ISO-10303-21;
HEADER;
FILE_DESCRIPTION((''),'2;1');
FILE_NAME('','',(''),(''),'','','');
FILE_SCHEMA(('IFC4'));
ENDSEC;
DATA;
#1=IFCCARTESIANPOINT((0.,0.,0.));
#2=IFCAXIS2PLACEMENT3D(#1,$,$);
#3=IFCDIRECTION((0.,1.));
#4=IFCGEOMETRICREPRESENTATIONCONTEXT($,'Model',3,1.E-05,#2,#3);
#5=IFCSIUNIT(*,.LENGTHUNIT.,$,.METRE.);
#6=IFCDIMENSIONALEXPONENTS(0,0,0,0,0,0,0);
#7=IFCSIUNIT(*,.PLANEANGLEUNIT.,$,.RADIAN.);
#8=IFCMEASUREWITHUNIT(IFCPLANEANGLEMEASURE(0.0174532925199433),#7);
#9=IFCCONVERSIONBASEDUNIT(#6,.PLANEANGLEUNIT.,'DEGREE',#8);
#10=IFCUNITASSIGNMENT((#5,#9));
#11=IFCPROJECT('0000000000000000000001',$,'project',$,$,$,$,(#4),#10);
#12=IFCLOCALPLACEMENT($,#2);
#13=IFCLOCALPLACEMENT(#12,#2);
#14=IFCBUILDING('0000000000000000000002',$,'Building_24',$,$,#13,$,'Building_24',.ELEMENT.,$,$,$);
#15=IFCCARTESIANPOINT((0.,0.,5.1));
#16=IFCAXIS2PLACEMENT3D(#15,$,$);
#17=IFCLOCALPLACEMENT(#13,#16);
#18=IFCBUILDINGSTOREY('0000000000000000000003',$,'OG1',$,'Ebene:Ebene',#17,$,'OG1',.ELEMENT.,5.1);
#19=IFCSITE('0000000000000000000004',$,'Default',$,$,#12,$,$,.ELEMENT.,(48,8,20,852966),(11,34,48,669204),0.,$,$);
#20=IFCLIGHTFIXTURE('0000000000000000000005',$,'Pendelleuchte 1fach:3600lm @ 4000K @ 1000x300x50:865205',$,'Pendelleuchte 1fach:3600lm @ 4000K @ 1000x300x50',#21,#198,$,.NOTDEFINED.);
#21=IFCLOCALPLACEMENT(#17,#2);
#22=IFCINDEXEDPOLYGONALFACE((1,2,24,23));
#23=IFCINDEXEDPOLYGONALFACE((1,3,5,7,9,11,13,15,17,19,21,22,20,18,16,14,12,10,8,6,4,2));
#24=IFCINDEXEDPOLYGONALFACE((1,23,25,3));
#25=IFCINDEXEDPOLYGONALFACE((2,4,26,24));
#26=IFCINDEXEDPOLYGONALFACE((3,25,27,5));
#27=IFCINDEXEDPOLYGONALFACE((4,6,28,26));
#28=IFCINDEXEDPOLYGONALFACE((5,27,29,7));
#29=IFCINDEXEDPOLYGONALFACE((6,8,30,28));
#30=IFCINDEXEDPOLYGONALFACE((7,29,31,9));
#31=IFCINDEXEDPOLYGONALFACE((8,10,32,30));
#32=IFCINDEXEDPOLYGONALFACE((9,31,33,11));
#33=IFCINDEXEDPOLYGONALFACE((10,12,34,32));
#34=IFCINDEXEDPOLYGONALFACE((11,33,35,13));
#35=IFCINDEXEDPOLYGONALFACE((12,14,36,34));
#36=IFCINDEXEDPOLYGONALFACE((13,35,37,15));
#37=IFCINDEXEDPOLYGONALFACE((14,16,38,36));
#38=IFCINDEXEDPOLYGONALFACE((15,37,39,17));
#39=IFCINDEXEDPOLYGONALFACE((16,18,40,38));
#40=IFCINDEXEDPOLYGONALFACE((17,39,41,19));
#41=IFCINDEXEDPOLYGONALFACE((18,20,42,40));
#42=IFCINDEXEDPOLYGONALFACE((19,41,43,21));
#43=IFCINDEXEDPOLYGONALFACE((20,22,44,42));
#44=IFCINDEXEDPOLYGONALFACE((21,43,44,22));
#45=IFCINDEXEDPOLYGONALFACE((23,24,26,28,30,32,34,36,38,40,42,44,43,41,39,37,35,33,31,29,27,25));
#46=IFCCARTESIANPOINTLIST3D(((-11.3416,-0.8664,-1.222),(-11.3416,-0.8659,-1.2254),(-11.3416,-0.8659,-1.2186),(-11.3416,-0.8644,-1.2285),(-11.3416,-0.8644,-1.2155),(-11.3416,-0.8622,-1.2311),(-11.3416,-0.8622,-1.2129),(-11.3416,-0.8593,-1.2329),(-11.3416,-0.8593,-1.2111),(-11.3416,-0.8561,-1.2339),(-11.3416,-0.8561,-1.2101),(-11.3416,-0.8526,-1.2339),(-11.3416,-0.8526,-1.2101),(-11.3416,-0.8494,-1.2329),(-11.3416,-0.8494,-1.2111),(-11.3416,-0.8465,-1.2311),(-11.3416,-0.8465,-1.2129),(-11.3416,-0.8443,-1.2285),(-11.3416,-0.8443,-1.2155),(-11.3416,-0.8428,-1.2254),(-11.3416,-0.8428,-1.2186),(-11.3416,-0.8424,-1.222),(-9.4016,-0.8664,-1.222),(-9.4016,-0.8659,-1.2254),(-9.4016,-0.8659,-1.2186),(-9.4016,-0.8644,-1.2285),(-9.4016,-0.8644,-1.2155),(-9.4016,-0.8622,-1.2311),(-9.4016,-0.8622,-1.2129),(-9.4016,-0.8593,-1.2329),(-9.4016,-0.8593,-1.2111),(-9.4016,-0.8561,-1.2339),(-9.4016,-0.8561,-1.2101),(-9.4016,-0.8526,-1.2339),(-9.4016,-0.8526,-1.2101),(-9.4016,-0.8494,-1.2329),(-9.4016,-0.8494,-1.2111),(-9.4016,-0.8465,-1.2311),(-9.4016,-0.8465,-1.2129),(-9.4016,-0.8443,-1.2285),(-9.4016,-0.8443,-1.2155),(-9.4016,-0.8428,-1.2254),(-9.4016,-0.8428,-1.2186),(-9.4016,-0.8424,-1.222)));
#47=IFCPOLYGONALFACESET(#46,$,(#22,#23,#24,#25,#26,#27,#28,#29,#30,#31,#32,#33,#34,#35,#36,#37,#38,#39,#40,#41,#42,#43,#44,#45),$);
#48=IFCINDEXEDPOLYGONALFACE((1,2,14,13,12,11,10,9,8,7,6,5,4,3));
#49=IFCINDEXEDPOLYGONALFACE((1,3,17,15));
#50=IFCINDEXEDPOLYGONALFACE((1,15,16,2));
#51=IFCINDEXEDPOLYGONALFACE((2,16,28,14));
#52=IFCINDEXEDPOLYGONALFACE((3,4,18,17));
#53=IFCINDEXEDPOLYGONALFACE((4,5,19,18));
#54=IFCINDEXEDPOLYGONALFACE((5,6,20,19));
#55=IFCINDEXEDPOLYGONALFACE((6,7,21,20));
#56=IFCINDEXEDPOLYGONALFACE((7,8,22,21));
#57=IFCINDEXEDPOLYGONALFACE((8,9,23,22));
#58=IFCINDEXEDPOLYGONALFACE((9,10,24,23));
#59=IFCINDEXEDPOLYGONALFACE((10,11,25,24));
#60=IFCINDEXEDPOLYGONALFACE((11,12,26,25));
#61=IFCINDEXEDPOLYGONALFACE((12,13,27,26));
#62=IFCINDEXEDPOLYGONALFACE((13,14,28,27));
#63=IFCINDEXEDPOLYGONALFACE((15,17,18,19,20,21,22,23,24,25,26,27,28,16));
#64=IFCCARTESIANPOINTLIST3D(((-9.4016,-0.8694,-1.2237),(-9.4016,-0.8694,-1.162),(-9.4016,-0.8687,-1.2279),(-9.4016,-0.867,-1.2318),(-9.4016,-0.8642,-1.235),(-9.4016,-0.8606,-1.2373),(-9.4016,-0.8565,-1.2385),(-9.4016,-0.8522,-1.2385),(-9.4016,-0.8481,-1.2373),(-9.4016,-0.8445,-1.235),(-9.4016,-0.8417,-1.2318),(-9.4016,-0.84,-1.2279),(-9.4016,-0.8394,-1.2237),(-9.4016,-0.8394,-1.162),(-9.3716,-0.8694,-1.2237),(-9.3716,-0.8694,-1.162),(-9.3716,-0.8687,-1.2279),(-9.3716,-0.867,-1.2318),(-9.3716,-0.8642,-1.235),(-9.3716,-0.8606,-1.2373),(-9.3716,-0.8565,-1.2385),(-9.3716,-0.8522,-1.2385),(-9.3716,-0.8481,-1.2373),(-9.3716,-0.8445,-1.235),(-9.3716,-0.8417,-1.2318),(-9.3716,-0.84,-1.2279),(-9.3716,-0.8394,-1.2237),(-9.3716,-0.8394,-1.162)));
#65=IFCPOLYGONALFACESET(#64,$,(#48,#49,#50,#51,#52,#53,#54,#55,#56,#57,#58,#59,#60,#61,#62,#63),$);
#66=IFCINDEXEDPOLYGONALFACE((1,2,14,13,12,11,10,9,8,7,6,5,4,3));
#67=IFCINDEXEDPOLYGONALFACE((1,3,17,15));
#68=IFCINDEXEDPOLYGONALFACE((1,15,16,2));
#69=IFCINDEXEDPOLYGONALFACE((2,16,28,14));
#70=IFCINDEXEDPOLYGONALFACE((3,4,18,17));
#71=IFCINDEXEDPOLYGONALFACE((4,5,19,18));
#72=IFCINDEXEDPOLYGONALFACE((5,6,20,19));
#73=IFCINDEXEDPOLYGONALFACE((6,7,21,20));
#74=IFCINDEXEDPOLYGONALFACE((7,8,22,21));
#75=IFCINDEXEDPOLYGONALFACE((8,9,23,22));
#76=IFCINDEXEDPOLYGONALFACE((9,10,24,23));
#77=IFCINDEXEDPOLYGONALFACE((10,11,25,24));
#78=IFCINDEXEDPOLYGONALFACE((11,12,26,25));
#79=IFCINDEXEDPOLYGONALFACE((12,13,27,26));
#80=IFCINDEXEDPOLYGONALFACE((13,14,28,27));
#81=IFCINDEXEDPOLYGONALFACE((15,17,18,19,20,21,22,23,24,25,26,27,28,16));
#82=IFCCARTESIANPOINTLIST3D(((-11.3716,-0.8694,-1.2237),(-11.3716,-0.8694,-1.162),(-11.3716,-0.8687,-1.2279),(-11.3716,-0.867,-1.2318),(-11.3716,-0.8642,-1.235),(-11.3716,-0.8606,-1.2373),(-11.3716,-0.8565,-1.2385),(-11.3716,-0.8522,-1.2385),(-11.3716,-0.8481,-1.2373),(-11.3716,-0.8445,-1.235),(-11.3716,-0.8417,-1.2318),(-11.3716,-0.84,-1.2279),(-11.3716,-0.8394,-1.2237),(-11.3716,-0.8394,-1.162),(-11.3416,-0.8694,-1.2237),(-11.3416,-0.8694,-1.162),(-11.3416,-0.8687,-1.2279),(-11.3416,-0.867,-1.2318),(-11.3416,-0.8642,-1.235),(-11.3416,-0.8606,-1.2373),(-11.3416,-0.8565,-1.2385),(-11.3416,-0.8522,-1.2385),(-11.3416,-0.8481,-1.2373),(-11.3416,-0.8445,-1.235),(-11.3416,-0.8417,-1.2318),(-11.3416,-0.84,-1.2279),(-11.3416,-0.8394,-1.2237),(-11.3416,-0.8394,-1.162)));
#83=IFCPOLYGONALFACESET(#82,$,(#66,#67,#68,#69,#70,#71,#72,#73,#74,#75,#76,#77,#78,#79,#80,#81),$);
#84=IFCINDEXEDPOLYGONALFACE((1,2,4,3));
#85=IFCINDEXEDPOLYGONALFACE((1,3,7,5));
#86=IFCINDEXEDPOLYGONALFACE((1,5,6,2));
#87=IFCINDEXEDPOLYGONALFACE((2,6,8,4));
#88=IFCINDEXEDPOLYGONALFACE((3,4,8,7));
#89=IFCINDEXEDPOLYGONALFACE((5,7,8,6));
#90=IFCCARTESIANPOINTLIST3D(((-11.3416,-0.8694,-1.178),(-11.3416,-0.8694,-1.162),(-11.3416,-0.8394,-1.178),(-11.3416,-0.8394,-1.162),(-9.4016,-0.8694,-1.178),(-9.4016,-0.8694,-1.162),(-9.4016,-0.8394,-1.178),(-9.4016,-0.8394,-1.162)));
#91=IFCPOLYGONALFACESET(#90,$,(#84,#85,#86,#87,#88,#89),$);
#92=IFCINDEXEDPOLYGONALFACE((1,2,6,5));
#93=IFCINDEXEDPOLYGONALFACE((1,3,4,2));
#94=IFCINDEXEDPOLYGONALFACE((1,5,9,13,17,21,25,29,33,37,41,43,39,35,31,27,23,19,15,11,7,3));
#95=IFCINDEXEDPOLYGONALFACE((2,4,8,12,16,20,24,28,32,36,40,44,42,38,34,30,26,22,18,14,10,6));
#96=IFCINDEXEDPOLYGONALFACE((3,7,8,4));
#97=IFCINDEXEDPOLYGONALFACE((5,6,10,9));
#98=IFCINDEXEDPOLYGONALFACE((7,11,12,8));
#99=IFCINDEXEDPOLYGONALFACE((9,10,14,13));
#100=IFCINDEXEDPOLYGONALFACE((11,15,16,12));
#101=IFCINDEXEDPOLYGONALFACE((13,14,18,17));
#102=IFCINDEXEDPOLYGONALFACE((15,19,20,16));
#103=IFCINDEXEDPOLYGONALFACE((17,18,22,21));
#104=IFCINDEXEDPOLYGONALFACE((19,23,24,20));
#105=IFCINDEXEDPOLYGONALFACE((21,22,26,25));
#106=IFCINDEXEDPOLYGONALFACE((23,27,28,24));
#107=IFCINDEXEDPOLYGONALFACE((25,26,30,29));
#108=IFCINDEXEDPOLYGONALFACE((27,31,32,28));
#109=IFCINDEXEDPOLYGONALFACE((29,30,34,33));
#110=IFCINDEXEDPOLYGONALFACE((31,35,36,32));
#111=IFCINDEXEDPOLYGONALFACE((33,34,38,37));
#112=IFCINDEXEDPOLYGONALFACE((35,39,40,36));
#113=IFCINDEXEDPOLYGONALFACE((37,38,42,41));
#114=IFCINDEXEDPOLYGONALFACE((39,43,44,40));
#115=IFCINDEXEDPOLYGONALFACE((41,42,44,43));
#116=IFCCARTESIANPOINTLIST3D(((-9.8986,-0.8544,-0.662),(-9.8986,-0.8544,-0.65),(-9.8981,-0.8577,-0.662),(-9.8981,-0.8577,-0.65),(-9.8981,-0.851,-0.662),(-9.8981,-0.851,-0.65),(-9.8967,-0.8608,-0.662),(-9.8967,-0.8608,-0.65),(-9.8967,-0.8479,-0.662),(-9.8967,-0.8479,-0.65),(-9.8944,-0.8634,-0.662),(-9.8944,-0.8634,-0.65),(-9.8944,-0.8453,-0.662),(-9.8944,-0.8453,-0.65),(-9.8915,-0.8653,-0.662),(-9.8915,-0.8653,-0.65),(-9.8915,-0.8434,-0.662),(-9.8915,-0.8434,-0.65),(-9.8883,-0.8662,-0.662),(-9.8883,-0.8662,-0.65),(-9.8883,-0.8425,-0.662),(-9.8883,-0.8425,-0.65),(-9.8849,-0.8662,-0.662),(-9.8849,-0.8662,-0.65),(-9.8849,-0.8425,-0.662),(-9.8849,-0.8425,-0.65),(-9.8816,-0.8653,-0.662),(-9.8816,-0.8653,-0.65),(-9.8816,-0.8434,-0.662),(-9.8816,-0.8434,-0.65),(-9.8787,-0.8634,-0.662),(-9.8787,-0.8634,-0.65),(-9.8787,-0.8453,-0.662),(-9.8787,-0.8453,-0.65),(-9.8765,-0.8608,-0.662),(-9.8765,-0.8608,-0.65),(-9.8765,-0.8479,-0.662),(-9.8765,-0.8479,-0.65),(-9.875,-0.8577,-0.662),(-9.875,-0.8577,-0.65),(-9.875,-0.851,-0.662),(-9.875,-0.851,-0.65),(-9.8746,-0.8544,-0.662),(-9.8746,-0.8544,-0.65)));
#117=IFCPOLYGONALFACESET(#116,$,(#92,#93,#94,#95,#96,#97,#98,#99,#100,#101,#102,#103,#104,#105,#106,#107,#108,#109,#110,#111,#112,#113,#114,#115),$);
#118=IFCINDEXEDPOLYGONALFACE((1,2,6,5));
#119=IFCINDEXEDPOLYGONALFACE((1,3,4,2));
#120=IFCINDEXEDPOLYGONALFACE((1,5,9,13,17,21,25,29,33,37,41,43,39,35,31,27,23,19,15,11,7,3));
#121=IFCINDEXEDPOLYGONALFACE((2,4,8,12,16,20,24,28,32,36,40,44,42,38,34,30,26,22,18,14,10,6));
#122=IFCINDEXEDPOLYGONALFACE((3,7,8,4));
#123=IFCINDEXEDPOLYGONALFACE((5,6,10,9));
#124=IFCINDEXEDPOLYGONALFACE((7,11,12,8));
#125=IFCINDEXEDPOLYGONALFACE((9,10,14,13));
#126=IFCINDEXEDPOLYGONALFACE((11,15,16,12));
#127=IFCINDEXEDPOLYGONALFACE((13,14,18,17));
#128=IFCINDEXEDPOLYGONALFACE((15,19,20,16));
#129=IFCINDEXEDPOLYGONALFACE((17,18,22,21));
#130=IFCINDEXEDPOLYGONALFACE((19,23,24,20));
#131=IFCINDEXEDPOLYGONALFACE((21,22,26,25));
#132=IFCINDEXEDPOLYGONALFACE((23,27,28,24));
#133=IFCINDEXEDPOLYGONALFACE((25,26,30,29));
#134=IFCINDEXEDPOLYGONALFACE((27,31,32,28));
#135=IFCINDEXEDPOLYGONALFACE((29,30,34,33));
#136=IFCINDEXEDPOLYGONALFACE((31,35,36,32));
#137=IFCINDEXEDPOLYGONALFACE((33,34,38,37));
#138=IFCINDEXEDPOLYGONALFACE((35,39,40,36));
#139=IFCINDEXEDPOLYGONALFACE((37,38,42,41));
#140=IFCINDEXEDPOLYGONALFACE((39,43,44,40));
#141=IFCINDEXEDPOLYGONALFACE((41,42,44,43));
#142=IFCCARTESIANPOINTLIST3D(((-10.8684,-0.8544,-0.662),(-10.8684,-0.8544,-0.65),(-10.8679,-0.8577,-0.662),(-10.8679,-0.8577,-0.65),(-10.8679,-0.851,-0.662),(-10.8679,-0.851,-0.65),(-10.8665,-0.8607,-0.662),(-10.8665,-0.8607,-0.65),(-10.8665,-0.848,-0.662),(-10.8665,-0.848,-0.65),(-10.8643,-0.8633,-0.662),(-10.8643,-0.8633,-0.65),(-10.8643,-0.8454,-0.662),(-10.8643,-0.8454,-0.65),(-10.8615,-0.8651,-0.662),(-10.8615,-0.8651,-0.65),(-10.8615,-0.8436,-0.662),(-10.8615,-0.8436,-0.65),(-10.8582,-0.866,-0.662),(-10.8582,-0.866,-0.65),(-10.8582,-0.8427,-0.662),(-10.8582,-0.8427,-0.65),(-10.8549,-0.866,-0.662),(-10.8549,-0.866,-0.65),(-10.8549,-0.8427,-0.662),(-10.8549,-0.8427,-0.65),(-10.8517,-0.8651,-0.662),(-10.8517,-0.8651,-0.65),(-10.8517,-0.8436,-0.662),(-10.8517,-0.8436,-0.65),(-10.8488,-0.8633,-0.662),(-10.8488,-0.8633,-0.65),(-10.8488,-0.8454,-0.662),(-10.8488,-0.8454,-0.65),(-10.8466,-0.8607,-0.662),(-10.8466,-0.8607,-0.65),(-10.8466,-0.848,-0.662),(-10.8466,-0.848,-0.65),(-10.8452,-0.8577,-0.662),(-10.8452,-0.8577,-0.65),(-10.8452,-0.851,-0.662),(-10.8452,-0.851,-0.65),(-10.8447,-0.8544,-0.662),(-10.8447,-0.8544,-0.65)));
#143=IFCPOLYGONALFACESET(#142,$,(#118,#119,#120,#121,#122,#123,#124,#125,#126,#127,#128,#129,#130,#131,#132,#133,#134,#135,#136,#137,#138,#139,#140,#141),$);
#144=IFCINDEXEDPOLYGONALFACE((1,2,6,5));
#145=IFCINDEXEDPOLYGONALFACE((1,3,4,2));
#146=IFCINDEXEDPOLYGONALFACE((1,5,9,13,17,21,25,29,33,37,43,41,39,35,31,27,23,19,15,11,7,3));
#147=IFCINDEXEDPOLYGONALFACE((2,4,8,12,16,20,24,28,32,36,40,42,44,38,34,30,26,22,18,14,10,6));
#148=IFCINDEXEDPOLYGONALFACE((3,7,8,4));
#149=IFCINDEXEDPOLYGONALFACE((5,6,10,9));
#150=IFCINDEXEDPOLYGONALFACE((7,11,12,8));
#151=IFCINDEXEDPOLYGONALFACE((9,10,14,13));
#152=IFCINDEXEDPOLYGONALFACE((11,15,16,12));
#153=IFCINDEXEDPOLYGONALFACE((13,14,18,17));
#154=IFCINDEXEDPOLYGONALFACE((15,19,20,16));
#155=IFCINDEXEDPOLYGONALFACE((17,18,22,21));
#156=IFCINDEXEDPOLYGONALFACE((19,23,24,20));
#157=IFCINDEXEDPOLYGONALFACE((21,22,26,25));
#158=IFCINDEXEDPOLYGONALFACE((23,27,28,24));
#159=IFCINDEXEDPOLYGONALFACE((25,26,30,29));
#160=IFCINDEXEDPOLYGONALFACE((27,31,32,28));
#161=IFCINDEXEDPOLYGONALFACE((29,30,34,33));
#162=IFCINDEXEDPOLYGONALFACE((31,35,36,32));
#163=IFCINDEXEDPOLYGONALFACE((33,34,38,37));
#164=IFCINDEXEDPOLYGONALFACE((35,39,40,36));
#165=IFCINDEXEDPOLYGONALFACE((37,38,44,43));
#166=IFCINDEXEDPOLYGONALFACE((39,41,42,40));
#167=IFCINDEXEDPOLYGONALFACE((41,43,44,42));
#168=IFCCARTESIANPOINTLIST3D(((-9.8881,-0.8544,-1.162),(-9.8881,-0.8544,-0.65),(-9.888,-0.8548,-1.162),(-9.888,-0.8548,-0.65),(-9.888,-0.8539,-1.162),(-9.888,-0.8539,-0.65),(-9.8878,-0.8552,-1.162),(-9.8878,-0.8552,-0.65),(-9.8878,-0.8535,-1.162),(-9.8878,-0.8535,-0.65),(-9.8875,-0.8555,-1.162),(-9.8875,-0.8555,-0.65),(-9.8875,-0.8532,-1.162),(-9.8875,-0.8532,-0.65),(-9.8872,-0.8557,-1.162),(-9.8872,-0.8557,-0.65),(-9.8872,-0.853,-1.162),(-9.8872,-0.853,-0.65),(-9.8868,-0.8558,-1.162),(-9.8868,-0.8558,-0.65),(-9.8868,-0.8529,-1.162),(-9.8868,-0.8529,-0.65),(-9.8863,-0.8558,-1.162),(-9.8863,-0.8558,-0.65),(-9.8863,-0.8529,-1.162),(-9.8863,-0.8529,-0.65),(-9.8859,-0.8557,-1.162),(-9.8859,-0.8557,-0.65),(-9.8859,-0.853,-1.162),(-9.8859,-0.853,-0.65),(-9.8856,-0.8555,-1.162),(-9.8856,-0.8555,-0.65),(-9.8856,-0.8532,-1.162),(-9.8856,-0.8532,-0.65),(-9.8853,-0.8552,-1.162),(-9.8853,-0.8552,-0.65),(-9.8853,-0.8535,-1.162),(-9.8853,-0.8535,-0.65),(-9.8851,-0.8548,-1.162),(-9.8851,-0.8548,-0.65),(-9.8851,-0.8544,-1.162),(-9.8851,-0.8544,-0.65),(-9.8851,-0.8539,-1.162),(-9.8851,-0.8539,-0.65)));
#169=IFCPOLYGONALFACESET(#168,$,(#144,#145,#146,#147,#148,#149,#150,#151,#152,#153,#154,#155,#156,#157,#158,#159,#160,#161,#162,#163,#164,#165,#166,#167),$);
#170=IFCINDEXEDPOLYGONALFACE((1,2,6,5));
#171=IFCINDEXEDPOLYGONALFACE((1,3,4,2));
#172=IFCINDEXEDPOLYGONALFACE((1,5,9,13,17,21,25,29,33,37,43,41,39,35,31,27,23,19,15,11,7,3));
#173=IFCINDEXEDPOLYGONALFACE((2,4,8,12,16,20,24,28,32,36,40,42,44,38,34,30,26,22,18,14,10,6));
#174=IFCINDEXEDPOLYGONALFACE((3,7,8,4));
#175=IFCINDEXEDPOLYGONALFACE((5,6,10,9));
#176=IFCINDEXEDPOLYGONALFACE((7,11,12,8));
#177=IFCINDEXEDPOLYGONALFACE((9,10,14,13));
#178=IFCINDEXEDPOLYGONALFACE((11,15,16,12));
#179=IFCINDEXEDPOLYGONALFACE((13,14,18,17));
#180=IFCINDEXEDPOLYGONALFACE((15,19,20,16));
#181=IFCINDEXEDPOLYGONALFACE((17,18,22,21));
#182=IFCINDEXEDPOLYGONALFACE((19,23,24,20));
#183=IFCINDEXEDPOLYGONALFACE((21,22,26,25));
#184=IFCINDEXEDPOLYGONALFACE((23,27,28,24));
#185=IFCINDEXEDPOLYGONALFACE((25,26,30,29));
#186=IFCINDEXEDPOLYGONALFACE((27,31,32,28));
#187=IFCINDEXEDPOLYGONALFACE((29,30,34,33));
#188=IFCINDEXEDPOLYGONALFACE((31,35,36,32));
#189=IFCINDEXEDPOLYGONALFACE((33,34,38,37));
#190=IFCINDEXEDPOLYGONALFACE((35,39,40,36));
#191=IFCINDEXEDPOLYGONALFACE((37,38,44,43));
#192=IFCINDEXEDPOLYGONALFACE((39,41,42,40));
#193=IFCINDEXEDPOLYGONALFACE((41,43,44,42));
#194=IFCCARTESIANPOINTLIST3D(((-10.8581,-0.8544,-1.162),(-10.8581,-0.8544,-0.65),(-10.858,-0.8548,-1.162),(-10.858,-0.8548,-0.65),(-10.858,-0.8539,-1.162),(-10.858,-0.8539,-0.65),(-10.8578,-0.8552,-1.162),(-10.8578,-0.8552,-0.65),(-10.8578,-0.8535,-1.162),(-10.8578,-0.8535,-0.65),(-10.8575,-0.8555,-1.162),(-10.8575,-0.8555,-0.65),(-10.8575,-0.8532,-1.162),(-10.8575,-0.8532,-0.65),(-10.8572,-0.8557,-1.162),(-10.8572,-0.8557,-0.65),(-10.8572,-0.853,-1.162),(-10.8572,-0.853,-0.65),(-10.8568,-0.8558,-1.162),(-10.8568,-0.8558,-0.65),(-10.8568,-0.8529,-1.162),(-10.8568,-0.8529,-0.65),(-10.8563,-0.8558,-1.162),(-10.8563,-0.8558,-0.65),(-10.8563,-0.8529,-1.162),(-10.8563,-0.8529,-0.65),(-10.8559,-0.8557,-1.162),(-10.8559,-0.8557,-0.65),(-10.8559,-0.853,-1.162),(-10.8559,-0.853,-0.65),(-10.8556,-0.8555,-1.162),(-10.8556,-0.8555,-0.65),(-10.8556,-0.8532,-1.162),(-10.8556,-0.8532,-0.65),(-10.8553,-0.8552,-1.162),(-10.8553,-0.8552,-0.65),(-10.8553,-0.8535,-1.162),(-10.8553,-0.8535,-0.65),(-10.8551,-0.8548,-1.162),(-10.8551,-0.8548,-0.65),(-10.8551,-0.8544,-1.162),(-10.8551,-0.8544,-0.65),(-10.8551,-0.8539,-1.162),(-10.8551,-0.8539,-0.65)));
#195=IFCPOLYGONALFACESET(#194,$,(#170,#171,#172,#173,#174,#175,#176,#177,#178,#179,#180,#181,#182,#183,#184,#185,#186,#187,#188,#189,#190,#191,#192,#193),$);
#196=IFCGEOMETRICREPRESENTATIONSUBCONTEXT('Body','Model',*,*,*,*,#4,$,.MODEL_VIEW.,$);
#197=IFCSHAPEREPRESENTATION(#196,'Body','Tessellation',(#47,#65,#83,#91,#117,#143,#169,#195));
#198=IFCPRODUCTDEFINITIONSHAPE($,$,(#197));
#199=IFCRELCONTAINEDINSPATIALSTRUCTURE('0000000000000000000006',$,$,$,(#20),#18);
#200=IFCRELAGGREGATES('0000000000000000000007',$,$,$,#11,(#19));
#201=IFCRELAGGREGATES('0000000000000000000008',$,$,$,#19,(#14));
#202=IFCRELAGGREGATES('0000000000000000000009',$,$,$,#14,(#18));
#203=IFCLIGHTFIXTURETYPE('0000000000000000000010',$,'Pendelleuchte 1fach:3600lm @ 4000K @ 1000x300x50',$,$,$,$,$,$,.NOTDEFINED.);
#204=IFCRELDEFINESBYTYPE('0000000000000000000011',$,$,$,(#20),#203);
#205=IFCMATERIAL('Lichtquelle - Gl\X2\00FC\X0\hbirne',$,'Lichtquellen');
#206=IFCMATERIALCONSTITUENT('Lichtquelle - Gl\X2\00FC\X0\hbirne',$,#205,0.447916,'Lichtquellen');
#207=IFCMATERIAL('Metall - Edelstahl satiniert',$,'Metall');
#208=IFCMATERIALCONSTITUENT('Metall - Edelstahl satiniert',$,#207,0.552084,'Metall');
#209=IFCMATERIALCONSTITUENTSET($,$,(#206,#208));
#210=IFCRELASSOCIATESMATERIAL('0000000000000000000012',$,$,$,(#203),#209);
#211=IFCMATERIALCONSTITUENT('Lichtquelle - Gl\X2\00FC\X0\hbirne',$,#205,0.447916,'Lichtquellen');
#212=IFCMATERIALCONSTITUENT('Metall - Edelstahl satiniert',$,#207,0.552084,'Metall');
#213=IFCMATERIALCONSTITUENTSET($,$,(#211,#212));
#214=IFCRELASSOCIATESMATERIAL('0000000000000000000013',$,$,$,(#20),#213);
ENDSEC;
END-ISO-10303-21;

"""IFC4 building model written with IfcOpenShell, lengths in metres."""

from ifc_helpers import new_model, entity, si_unit, converted_unit, direction, frame, origin, place, context, subcontext, project, spatial, line, arc, indexed_curve, outline, extrude, source, transform, mapped, material, constituent, constituent_set, type_object, type_shapes, element, save


model = new_model("IFC4")

# Units and contexts
model_context = context("Model", 3, precision=1e-05, world=origin(), true_north=direction((0.0, 1.0)))
body_context = subcontext(model_context, "Body", "Model", "MODEL_VIEW")
ifc_project = project(units=[si_unit("LENGTHUNIT", "METRE"), converted_unit("PLANEANGLEUNIT", "DEGREE", entity("IfcPlaneAngleMeasure", 0.0174532925199433), si_unit("PLANEANGLEUNIT", "RADIAN"), dimensions=[0, 0, 0, 0, 0, 0, 0])], contexts=[model_context])

# Site, building, storey
site_placement = place(None, origin())
site = spatial("IfcSite", under=ifc_project, at=site_placement, Name="Default", CompositionType="ELEMENT", RefLatitude=(48, 8, 20, 852966), RefLongitude=(11, 34, 48, 669204), RefElevation=0.0)
building_placement = place(site_placement, origin())
building = spatial("IfcBuilding", under=site, at=building_placement, Name="Building_24", LongName="Building_24", CompositionType="ELEMENT")
storey_placement = place(building_placement, frame((0.0, 0.0, 5.1)))
storey = spatial("IfcBuildingStorey", under=building, at=storey_placement, Name="OG1", ObjectType="Ebene:Ebene", LongName="OG1", CompositionType="ELEMENT", Elevation=5.1)

# Light fixture
ifc_material_1 = material(Name="Lichtquelle - Glühbirne", Category="Lichtquellen")
ifc_constituent_1 = constituent(ifc_material_1, Name="Lichtquelle - Glühbirne", Category="Lichtquellen", fraction=0.447916)
ifc_material_2 = material(Name="Metall - Edelstahl satiniert", Category="Metall")
ifc_constituent_2 = constituent(ifc_material_2, Name="Metall - Edelstahl satiniert", Category="Metall", fraction=0.552084)
ifc_constituent_set_1 = constituent_set(constituents=[ifc_constituent_1, ifc_constituent_2])
ifc_constituent_3 = constituent(ifc_material_1, Name="Lichtquelle - Glühbirne", Category="Lichtquellen", fraction=0.447916)
ifc_constituent_4 = constituent(ifc_material_2, Name="Metall - Edelstahl satiniert", Category="Metall", fraction=0.552084)
ifc_constituent_set_2 = constituent_set(constituents=[ifc_constituent_3, ifc_constituent_4])
light_fixture_type_1 = type_object("IfcLightFixtureType", Name="Pendelleuchte 1fach:3600lm @ 4000K @ 1000x300x50", PredefinedType="NOTDEFINED", material=ifc_constituent_set_2)
shared_shape_1 = source(origin(), body_context, "Body", "SweptSolid", [
    extrude(outline(indexed_curve([(-0.012, 0.0), (0.0, -0.012), (0.012, 0.0), (0.0, 0.012)], segments=[arc(1, 2, 3), arc(3, 4, 1)], self_intersect=False)), frame((-0.97, 0.0, -0.572), z_axis=(1.0, 0.0, 0.0), x_axis=(0.0, 1.0, 0.0)), (0.0, 0.0, 1.0), 1.94),
    extrude(outline(indexed_curve([(-0.0308, -0.015), (0.0308, -0.015), (0.0308, 0.015), (-0.0308, 0.015), (-0.0458, 0.0)], segments=[line(1, 2, 3, 4), arc(4, 5, 1)], self_intersect=False)), frame((0.97, 0.0, -0.5428), z_axis=(1.0, 0.0, 0.0), x_axis=(0.0, 0.0, 1.0)), (0.0, 0.0, 1.0), 0.03),
    extrude(outline(indexed_curve([(-0.0308, -0.015), (0.0308, -0.015), (0.0308, 0.015), (-0.0308, 0.015), (-0.0458, 0.0)], segments=[line(1, 2, 3, 4), arc(4, 5, 1)], self_intersect=False)), frame((-1.0, 0.0, -0.5428), z_axis=(1.0, 0.0, 0.0), x_axis=(0.0, 0.0, 1.0)), (0.0, 0.0, 1.0), 0.03),
    extrude(outline(indexed_curve([(-0.97, -0.015), (0.97, -0.015), (0.97, 0.015), (-0.97, 0.015), (-0.97, -0.015)], self_intersect=False)), frame((0.0, 0.0, -0.528), z_axis=(0.0, 0.0, 1.0), x_axis=(-1.0, 0.0, 0.0)), (0.0, 0.0, 1.0), 0.016),
    extrude(outline(indexed_curve([(-0.012, 0.0), (0.0, -0.012), (0.012, 0.0), (0.0, 0.012)], segments=[arc(1, 2, 3), arc(3, 4, 1)], self_intersect=False)), frame((0.485, 0.0, -0.012)), (0.0, 0.0, 1.0), 0.012),
    extrude(outline(indexed_curve([(-0.0118, 0.0), (0.0, -0.0118), (0.0118, 0.0), (0.0, 0.0118)], segments=[arc(1, 2, 3), arc(3, 4, 1)], self_intersect=False)), frame((-0.485, 0.0, -0.012)), (0.0, 0.0, 1.0), 0.012),
    extrude(outline(indexed_curve([(-0.0015, 0.0), (0.0, -0.0015), (0.0015, 0.0), (0.0, 0.0015)], segments=[arc(1, 2, 3), arc(3, 4, 1)], self_intersect=False)), frame((0.485, 0.0, -0.512)), (0.0, 0.0, 1.0), 0.512),
    extrude(outline(indexed_curve([(-0.0015, 0.0), (0.0, -0.0015), (0.0015, 0.0), (0.0, 0.0015)], segments=[arc(1, 2, 3), arc(3, 4, 1)], self_intersect=False)), frame((-0.485, 0.0, -0.512)), (0.0, 0.0, 1.0), 0.512),
])
type_shapes(light_fixture_type_1, [shared_shape_1])
light_fixture_1_placement = place(storey_placement, frame((-10.3716, -0.8544, -0.65)))
element("IfcLightFixture", 1, at=light_fixture_1_placement, inside=storey, type_object=light_fixture_type_1, material=ifc_constituent_set_1, Name="Pendelleuchte 1fach:3600lm @ 4000K @ 1000x300x50:865205", ObjectType="Pendelleuchte 1fach:3600lm @ 4000K @ 1000x300x50", PredefinedType="NOTDEFINED", context=body_context, shape_type="MappedRepresentation", body=[
    mapped(shared_shape_1, transform((0.0, 0.0, 0.0), scale=1.0)),
])

save(model, "model.ifc")
